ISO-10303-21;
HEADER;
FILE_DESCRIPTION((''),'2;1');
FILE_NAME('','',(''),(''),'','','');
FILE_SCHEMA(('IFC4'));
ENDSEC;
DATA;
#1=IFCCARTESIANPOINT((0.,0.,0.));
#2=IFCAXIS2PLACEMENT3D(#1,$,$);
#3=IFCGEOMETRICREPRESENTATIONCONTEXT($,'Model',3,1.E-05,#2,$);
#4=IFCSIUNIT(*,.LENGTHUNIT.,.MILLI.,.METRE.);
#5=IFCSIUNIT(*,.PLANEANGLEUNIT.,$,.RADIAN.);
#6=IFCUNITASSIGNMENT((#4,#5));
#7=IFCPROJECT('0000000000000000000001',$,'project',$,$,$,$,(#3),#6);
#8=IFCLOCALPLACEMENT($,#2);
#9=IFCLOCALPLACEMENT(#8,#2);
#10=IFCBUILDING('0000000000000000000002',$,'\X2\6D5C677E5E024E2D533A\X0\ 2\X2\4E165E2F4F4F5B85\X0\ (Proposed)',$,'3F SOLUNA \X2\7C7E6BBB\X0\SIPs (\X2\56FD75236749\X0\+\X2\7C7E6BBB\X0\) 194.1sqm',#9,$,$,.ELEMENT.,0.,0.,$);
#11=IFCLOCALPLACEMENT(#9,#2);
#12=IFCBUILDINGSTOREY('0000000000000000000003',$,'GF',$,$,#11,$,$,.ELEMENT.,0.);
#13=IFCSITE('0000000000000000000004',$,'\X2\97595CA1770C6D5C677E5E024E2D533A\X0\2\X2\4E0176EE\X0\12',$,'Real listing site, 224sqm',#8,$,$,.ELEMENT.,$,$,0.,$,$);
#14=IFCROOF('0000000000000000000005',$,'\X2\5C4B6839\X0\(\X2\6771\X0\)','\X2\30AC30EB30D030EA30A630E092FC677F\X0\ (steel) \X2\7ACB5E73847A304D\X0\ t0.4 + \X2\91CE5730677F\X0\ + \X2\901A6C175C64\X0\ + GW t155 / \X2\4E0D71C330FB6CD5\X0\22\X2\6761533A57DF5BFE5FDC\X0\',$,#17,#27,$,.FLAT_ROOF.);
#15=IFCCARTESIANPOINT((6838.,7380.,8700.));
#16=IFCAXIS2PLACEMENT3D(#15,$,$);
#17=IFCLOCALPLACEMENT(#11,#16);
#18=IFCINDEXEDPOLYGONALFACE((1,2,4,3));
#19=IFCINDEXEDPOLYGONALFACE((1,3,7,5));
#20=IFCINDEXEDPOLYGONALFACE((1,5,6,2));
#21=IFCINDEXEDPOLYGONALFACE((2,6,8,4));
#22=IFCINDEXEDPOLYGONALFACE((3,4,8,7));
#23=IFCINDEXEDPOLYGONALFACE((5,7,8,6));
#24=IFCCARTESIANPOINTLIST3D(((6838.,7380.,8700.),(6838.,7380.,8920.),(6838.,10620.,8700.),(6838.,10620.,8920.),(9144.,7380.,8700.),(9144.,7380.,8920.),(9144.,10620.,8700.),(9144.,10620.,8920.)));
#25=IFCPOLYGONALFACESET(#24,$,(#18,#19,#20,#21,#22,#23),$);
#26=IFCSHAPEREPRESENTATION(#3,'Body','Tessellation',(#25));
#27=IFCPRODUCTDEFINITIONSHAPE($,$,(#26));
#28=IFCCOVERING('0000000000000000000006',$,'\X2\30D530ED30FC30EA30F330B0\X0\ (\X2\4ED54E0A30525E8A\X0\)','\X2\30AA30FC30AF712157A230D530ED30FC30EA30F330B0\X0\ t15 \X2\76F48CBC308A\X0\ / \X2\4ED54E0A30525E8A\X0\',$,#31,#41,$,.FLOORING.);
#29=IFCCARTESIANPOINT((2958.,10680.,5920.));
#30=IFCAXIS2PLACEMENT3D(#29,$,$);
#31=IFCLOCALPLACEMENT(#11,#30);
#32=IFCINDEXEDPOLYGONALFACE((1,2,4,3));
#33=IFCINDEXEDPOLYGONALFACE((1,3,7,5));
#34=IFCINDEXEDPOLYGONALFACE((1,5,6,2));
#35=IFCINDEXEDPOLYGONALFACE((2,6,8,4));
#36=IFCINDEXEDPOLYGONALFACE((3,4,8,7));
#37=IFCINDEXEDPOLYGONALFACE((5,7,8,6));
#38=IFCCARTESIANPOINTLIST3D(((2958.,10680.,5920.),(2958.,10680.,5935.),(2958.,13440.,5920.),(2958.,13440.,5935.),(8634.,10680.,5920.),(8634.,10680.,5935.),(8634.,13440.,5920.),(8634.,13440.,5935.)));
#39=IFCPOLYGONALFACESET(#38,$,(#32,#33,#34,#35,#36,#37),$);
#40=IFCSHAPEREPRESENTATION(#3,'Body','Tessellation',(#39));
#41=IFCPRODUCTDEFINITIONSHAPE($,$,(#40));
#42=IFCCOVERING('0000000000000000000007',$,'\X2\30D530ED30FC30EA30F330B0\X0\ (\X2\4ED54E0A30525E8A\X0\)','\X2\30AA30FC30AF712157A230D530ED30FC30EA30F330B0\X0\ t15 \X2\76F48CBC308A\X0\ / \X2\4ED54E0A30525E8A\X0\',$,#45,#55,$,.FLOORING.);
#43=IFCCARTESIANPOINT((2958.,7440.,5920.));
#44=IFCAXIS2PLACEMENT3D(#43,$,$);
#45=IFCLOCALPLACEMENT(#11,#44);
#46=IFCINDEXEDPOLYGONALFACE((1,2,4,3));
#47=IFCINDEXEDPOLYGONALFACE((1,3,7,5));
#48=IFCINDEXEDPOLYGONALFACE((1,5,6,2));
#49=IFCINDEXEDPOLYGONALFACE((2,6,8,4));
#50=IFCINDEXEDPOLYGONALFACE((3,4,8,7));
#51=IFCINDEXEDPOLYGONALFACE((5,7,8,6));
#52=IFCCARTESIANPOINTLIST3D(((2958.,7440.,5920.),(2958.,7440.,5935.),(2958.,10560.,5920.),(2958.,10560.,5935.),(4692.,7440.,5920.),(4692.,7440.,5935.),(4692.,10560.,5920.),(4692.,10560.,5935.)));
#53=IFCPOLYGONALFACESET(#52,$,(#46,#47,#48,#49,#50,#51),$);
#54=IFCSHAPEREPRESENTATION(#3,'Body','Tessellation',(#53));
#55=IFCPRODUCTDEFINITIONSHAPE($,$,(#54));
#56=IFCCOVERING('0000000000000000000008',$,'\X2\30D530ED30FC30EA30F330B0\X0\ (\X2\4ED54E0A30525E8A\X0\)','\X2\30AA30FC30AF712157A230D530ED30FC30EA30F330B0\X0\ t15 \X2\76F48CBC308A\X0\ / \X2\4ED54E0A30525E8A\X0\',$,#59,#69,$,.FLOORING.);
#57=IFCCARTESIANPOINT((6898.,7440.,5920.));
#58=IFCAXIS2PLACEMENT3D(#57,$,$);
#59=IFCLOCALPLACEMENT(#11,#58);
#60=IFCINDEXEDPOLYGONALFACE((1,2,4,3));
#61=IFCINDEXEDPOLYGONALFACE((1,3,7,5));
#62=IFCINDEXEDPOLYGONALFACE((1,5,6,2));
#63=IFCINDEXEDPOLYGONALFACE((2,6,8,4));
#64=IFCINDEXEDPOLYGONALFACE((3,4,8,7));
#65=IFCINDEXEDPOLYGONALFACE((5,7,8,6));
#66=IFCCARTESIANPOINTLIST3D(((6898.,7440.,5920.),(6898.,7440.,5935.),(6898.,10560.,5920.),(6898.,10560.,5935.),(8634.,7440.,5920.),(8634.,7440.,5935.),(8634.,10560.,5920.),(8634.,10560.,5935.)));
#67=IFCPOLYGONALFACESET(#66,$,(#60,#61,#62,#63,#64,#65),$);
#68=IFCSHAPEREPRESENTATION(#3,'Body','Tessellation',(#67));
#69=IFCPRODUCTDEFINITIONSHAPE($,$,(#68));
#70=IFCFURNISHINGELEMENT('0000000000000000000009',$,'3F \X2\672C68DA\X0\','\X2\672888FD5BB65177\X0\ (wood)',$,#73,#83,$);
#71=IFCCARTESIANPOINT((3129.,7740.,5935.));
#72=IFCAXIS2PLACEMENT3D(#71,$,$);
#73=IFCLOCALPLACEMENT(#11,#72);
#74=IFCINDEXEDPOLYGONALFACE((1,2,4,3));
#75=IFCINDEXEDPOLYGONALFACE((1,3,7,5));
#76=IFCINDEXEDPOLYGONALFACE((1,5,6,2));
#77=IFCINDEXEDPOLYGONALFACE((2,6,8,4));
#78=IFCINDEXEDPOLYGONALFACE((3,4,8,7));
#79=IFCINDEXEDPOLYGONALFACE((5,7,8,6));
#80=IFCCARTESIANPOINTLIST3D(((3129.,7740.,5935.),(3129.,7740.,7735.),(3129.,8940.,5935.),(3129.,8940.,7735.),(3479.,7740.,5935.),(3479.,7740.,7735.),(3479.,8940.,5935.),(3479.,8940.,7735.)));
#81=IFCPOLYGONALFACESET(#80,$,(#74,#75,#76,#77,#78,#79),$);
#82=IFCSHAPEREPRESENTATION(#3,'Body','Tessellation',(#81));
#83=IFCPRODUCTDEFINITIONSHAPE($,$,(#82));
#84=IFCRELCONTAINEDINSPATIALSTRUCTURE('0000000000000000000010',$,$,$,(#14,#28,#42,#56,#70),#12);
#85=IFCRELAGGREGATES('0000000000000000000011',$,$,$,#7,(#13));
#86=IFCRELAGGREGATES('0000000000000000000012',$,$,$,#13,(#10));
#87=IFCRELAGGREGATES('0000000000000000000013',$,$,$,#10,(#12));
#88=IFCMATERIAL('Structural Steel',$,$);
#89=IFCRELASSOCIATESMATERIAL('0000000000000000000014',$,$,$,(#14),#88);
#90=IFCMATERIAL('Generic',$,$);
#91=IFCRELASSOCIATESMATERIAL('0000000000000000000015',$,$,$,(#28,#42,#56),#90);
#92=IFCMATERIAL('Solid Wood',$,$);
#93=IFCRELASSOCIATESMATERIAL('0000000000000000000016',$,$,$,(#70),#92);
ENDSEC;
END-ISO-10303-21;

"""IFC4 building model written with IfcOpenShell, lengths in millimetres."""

from ifc_helpers import new_model, si_unit, frame, frame_2d, origin, place, context, project, spatial, rectangle, extrude, material, element, save


model = new_model("IFC4")

# Units and contexts
model_context = context("Model", 3, precision=1e-05, world=origin())
ifc_project = project(units=[si_unit("LENGTHUNIT", "METRE", prefix="MILLI"), si_unit("PLANEANGLEUNIT", "RADIAN")], contexts=[model_context])

# Site, building, storey
site_placement = place(None, origin())
site = spatial("IfcSite", under=ifc_project, at=site_placement, Name="静岡県浜松市中区2丁目12", ObjectType="Real listing site, 224sqm", CompositionType="ELEMENT", RefElevation=0.0)
building_placement = place(site_placement, origin())
building = spatial("IfcBuilding", under=site, at=building_placement, Name="浜松市中区 2世帯住宅 (Proposed)", ObjectType="3F SOLUNA 籾殻SIPs (国産杉+籾殻) 194.1sqm", CompositionType="ELEMENT", ElevationOfRefHeight=0.0, ElevationOfTerrain=0.0)
storey_placement = place(building_placement, origin())
storey = spatial("IfcBuildingStorey", under=building, at=storey_placement, Name="GF", CompositionType="ELEMENT", Elevation=0.0)

# Shared definitions
ifc_material_1 = material(Name="Solid Wood")

# Shared definitions
ifc_material_2 = material(Name="Generic")

# Roof
ifc_material_3 = material(Name="Structural Steel")
roof_1_placement = place(storey_placement, frame((6838.0, 7380.0, 8700.0)))
element("IfcRoof", 1, at=roof_1_placement, inside=storey, material=ifc_material_3, Name="屋根(東)", Description="ガルバリウム鋼板 (steel) 立平葺き t0.4 + 野地板 + 通気層 + GW t155 / 不燃・法22条区域対応", PredefinedType="FLAT_ROOF", context=model_context, shape_type="SweptSolid", body=[
    extrude(rectangle(XDim=2306.0, YDim=3240.0, at=frame_2d((1153.0, 1620.0))), frame((6838.0, 7380.0, 8700.0)), (0.0, 0.0, 1.0), 220.0),
])

# Coverings
covering_1_placement = place(storey_placement, frame((2958.0, 10680.0, 5920.0)))
element("IfcCovering", 2, at=covering_1_placement, inside=storey, material=ifc_material_2, Name="フローリング (仕上げ床)", Description="オーク無垢フローリング t15 直貼り / 仕上げ床", PredefinedType="FLOORING", context=model_context, shape_type="SweptSolid", body=[
    extrude(rectangle(XDim=5676.0, YDim=2760.0, at=frame_2d((2838.0, 1380.0))), frame((2958.0, 10680.0, 5920.0)), (0.0, 0.0, 1.0), 15.0),
])
covering_2_placement = place(storey_placement, frame((2958.0, 7440.0, 5920.0)))
element("IfcCovering", 3, at=covering_2_placement, inside=storey, material=ifc_material_2, Name="フローリング (仕上げ床)", Description="オーク無垢フローリング t15 直貼り / 仕上げ床", PredefinedType="FLOORING", context=model_context, shape_type="SweptSolid", body=[
    extrude(rectangle(XDim=1734.0, YDim=3120.0, at=frame_2d((867.0, 1560.0))), frame((2958.0, 7440.0, 5920.0)), (0.0, 0.0, 1.0), 15.0),
])
covering_3_placement = place(storey_placement, frame((6898.0, 7440.0, 5920.0)))
element("IfcCovering", 4, at=covering_3_placement, inside=storey, material=ifc_material_2, Name="フローリング (仕上げ床)", Description="オーク無垢フローリング t15 直貼り / 仕上げ床", PredefinedType="FLOORING", context=model_context, shape_type="SweptSolid", body=[
    extrude(rectangle(XDim=1736.0, YDim=3120.0, at=frame_2d((868.0, 1560.0))), frame((6898.0, 7440.0, 5920.0)), (0.0, 0.0, 1.0), 15.0),
])

# Furnishing element
furnishing_placement = place(storey_placement, frame((3129.0, 7740.0, 5935.0)))
element("IfcFurnishingElement", 5, at=furnishing_placement, inside=storey, material=ifc_material_1, Name="3F 本棚", Description="木製家具 (wood)", context=model_context, shape_type="SweptSolid", body=[
    extrude(rectangle(XDim=350.0, YDim=1200.0, at=frame_2d((175.0, 600.0))), frame((3129.0, 7740.0, 5935.0)), (0.0, 0.0, 1.0), 1800.0),
])

save(model, "model.ifc")
